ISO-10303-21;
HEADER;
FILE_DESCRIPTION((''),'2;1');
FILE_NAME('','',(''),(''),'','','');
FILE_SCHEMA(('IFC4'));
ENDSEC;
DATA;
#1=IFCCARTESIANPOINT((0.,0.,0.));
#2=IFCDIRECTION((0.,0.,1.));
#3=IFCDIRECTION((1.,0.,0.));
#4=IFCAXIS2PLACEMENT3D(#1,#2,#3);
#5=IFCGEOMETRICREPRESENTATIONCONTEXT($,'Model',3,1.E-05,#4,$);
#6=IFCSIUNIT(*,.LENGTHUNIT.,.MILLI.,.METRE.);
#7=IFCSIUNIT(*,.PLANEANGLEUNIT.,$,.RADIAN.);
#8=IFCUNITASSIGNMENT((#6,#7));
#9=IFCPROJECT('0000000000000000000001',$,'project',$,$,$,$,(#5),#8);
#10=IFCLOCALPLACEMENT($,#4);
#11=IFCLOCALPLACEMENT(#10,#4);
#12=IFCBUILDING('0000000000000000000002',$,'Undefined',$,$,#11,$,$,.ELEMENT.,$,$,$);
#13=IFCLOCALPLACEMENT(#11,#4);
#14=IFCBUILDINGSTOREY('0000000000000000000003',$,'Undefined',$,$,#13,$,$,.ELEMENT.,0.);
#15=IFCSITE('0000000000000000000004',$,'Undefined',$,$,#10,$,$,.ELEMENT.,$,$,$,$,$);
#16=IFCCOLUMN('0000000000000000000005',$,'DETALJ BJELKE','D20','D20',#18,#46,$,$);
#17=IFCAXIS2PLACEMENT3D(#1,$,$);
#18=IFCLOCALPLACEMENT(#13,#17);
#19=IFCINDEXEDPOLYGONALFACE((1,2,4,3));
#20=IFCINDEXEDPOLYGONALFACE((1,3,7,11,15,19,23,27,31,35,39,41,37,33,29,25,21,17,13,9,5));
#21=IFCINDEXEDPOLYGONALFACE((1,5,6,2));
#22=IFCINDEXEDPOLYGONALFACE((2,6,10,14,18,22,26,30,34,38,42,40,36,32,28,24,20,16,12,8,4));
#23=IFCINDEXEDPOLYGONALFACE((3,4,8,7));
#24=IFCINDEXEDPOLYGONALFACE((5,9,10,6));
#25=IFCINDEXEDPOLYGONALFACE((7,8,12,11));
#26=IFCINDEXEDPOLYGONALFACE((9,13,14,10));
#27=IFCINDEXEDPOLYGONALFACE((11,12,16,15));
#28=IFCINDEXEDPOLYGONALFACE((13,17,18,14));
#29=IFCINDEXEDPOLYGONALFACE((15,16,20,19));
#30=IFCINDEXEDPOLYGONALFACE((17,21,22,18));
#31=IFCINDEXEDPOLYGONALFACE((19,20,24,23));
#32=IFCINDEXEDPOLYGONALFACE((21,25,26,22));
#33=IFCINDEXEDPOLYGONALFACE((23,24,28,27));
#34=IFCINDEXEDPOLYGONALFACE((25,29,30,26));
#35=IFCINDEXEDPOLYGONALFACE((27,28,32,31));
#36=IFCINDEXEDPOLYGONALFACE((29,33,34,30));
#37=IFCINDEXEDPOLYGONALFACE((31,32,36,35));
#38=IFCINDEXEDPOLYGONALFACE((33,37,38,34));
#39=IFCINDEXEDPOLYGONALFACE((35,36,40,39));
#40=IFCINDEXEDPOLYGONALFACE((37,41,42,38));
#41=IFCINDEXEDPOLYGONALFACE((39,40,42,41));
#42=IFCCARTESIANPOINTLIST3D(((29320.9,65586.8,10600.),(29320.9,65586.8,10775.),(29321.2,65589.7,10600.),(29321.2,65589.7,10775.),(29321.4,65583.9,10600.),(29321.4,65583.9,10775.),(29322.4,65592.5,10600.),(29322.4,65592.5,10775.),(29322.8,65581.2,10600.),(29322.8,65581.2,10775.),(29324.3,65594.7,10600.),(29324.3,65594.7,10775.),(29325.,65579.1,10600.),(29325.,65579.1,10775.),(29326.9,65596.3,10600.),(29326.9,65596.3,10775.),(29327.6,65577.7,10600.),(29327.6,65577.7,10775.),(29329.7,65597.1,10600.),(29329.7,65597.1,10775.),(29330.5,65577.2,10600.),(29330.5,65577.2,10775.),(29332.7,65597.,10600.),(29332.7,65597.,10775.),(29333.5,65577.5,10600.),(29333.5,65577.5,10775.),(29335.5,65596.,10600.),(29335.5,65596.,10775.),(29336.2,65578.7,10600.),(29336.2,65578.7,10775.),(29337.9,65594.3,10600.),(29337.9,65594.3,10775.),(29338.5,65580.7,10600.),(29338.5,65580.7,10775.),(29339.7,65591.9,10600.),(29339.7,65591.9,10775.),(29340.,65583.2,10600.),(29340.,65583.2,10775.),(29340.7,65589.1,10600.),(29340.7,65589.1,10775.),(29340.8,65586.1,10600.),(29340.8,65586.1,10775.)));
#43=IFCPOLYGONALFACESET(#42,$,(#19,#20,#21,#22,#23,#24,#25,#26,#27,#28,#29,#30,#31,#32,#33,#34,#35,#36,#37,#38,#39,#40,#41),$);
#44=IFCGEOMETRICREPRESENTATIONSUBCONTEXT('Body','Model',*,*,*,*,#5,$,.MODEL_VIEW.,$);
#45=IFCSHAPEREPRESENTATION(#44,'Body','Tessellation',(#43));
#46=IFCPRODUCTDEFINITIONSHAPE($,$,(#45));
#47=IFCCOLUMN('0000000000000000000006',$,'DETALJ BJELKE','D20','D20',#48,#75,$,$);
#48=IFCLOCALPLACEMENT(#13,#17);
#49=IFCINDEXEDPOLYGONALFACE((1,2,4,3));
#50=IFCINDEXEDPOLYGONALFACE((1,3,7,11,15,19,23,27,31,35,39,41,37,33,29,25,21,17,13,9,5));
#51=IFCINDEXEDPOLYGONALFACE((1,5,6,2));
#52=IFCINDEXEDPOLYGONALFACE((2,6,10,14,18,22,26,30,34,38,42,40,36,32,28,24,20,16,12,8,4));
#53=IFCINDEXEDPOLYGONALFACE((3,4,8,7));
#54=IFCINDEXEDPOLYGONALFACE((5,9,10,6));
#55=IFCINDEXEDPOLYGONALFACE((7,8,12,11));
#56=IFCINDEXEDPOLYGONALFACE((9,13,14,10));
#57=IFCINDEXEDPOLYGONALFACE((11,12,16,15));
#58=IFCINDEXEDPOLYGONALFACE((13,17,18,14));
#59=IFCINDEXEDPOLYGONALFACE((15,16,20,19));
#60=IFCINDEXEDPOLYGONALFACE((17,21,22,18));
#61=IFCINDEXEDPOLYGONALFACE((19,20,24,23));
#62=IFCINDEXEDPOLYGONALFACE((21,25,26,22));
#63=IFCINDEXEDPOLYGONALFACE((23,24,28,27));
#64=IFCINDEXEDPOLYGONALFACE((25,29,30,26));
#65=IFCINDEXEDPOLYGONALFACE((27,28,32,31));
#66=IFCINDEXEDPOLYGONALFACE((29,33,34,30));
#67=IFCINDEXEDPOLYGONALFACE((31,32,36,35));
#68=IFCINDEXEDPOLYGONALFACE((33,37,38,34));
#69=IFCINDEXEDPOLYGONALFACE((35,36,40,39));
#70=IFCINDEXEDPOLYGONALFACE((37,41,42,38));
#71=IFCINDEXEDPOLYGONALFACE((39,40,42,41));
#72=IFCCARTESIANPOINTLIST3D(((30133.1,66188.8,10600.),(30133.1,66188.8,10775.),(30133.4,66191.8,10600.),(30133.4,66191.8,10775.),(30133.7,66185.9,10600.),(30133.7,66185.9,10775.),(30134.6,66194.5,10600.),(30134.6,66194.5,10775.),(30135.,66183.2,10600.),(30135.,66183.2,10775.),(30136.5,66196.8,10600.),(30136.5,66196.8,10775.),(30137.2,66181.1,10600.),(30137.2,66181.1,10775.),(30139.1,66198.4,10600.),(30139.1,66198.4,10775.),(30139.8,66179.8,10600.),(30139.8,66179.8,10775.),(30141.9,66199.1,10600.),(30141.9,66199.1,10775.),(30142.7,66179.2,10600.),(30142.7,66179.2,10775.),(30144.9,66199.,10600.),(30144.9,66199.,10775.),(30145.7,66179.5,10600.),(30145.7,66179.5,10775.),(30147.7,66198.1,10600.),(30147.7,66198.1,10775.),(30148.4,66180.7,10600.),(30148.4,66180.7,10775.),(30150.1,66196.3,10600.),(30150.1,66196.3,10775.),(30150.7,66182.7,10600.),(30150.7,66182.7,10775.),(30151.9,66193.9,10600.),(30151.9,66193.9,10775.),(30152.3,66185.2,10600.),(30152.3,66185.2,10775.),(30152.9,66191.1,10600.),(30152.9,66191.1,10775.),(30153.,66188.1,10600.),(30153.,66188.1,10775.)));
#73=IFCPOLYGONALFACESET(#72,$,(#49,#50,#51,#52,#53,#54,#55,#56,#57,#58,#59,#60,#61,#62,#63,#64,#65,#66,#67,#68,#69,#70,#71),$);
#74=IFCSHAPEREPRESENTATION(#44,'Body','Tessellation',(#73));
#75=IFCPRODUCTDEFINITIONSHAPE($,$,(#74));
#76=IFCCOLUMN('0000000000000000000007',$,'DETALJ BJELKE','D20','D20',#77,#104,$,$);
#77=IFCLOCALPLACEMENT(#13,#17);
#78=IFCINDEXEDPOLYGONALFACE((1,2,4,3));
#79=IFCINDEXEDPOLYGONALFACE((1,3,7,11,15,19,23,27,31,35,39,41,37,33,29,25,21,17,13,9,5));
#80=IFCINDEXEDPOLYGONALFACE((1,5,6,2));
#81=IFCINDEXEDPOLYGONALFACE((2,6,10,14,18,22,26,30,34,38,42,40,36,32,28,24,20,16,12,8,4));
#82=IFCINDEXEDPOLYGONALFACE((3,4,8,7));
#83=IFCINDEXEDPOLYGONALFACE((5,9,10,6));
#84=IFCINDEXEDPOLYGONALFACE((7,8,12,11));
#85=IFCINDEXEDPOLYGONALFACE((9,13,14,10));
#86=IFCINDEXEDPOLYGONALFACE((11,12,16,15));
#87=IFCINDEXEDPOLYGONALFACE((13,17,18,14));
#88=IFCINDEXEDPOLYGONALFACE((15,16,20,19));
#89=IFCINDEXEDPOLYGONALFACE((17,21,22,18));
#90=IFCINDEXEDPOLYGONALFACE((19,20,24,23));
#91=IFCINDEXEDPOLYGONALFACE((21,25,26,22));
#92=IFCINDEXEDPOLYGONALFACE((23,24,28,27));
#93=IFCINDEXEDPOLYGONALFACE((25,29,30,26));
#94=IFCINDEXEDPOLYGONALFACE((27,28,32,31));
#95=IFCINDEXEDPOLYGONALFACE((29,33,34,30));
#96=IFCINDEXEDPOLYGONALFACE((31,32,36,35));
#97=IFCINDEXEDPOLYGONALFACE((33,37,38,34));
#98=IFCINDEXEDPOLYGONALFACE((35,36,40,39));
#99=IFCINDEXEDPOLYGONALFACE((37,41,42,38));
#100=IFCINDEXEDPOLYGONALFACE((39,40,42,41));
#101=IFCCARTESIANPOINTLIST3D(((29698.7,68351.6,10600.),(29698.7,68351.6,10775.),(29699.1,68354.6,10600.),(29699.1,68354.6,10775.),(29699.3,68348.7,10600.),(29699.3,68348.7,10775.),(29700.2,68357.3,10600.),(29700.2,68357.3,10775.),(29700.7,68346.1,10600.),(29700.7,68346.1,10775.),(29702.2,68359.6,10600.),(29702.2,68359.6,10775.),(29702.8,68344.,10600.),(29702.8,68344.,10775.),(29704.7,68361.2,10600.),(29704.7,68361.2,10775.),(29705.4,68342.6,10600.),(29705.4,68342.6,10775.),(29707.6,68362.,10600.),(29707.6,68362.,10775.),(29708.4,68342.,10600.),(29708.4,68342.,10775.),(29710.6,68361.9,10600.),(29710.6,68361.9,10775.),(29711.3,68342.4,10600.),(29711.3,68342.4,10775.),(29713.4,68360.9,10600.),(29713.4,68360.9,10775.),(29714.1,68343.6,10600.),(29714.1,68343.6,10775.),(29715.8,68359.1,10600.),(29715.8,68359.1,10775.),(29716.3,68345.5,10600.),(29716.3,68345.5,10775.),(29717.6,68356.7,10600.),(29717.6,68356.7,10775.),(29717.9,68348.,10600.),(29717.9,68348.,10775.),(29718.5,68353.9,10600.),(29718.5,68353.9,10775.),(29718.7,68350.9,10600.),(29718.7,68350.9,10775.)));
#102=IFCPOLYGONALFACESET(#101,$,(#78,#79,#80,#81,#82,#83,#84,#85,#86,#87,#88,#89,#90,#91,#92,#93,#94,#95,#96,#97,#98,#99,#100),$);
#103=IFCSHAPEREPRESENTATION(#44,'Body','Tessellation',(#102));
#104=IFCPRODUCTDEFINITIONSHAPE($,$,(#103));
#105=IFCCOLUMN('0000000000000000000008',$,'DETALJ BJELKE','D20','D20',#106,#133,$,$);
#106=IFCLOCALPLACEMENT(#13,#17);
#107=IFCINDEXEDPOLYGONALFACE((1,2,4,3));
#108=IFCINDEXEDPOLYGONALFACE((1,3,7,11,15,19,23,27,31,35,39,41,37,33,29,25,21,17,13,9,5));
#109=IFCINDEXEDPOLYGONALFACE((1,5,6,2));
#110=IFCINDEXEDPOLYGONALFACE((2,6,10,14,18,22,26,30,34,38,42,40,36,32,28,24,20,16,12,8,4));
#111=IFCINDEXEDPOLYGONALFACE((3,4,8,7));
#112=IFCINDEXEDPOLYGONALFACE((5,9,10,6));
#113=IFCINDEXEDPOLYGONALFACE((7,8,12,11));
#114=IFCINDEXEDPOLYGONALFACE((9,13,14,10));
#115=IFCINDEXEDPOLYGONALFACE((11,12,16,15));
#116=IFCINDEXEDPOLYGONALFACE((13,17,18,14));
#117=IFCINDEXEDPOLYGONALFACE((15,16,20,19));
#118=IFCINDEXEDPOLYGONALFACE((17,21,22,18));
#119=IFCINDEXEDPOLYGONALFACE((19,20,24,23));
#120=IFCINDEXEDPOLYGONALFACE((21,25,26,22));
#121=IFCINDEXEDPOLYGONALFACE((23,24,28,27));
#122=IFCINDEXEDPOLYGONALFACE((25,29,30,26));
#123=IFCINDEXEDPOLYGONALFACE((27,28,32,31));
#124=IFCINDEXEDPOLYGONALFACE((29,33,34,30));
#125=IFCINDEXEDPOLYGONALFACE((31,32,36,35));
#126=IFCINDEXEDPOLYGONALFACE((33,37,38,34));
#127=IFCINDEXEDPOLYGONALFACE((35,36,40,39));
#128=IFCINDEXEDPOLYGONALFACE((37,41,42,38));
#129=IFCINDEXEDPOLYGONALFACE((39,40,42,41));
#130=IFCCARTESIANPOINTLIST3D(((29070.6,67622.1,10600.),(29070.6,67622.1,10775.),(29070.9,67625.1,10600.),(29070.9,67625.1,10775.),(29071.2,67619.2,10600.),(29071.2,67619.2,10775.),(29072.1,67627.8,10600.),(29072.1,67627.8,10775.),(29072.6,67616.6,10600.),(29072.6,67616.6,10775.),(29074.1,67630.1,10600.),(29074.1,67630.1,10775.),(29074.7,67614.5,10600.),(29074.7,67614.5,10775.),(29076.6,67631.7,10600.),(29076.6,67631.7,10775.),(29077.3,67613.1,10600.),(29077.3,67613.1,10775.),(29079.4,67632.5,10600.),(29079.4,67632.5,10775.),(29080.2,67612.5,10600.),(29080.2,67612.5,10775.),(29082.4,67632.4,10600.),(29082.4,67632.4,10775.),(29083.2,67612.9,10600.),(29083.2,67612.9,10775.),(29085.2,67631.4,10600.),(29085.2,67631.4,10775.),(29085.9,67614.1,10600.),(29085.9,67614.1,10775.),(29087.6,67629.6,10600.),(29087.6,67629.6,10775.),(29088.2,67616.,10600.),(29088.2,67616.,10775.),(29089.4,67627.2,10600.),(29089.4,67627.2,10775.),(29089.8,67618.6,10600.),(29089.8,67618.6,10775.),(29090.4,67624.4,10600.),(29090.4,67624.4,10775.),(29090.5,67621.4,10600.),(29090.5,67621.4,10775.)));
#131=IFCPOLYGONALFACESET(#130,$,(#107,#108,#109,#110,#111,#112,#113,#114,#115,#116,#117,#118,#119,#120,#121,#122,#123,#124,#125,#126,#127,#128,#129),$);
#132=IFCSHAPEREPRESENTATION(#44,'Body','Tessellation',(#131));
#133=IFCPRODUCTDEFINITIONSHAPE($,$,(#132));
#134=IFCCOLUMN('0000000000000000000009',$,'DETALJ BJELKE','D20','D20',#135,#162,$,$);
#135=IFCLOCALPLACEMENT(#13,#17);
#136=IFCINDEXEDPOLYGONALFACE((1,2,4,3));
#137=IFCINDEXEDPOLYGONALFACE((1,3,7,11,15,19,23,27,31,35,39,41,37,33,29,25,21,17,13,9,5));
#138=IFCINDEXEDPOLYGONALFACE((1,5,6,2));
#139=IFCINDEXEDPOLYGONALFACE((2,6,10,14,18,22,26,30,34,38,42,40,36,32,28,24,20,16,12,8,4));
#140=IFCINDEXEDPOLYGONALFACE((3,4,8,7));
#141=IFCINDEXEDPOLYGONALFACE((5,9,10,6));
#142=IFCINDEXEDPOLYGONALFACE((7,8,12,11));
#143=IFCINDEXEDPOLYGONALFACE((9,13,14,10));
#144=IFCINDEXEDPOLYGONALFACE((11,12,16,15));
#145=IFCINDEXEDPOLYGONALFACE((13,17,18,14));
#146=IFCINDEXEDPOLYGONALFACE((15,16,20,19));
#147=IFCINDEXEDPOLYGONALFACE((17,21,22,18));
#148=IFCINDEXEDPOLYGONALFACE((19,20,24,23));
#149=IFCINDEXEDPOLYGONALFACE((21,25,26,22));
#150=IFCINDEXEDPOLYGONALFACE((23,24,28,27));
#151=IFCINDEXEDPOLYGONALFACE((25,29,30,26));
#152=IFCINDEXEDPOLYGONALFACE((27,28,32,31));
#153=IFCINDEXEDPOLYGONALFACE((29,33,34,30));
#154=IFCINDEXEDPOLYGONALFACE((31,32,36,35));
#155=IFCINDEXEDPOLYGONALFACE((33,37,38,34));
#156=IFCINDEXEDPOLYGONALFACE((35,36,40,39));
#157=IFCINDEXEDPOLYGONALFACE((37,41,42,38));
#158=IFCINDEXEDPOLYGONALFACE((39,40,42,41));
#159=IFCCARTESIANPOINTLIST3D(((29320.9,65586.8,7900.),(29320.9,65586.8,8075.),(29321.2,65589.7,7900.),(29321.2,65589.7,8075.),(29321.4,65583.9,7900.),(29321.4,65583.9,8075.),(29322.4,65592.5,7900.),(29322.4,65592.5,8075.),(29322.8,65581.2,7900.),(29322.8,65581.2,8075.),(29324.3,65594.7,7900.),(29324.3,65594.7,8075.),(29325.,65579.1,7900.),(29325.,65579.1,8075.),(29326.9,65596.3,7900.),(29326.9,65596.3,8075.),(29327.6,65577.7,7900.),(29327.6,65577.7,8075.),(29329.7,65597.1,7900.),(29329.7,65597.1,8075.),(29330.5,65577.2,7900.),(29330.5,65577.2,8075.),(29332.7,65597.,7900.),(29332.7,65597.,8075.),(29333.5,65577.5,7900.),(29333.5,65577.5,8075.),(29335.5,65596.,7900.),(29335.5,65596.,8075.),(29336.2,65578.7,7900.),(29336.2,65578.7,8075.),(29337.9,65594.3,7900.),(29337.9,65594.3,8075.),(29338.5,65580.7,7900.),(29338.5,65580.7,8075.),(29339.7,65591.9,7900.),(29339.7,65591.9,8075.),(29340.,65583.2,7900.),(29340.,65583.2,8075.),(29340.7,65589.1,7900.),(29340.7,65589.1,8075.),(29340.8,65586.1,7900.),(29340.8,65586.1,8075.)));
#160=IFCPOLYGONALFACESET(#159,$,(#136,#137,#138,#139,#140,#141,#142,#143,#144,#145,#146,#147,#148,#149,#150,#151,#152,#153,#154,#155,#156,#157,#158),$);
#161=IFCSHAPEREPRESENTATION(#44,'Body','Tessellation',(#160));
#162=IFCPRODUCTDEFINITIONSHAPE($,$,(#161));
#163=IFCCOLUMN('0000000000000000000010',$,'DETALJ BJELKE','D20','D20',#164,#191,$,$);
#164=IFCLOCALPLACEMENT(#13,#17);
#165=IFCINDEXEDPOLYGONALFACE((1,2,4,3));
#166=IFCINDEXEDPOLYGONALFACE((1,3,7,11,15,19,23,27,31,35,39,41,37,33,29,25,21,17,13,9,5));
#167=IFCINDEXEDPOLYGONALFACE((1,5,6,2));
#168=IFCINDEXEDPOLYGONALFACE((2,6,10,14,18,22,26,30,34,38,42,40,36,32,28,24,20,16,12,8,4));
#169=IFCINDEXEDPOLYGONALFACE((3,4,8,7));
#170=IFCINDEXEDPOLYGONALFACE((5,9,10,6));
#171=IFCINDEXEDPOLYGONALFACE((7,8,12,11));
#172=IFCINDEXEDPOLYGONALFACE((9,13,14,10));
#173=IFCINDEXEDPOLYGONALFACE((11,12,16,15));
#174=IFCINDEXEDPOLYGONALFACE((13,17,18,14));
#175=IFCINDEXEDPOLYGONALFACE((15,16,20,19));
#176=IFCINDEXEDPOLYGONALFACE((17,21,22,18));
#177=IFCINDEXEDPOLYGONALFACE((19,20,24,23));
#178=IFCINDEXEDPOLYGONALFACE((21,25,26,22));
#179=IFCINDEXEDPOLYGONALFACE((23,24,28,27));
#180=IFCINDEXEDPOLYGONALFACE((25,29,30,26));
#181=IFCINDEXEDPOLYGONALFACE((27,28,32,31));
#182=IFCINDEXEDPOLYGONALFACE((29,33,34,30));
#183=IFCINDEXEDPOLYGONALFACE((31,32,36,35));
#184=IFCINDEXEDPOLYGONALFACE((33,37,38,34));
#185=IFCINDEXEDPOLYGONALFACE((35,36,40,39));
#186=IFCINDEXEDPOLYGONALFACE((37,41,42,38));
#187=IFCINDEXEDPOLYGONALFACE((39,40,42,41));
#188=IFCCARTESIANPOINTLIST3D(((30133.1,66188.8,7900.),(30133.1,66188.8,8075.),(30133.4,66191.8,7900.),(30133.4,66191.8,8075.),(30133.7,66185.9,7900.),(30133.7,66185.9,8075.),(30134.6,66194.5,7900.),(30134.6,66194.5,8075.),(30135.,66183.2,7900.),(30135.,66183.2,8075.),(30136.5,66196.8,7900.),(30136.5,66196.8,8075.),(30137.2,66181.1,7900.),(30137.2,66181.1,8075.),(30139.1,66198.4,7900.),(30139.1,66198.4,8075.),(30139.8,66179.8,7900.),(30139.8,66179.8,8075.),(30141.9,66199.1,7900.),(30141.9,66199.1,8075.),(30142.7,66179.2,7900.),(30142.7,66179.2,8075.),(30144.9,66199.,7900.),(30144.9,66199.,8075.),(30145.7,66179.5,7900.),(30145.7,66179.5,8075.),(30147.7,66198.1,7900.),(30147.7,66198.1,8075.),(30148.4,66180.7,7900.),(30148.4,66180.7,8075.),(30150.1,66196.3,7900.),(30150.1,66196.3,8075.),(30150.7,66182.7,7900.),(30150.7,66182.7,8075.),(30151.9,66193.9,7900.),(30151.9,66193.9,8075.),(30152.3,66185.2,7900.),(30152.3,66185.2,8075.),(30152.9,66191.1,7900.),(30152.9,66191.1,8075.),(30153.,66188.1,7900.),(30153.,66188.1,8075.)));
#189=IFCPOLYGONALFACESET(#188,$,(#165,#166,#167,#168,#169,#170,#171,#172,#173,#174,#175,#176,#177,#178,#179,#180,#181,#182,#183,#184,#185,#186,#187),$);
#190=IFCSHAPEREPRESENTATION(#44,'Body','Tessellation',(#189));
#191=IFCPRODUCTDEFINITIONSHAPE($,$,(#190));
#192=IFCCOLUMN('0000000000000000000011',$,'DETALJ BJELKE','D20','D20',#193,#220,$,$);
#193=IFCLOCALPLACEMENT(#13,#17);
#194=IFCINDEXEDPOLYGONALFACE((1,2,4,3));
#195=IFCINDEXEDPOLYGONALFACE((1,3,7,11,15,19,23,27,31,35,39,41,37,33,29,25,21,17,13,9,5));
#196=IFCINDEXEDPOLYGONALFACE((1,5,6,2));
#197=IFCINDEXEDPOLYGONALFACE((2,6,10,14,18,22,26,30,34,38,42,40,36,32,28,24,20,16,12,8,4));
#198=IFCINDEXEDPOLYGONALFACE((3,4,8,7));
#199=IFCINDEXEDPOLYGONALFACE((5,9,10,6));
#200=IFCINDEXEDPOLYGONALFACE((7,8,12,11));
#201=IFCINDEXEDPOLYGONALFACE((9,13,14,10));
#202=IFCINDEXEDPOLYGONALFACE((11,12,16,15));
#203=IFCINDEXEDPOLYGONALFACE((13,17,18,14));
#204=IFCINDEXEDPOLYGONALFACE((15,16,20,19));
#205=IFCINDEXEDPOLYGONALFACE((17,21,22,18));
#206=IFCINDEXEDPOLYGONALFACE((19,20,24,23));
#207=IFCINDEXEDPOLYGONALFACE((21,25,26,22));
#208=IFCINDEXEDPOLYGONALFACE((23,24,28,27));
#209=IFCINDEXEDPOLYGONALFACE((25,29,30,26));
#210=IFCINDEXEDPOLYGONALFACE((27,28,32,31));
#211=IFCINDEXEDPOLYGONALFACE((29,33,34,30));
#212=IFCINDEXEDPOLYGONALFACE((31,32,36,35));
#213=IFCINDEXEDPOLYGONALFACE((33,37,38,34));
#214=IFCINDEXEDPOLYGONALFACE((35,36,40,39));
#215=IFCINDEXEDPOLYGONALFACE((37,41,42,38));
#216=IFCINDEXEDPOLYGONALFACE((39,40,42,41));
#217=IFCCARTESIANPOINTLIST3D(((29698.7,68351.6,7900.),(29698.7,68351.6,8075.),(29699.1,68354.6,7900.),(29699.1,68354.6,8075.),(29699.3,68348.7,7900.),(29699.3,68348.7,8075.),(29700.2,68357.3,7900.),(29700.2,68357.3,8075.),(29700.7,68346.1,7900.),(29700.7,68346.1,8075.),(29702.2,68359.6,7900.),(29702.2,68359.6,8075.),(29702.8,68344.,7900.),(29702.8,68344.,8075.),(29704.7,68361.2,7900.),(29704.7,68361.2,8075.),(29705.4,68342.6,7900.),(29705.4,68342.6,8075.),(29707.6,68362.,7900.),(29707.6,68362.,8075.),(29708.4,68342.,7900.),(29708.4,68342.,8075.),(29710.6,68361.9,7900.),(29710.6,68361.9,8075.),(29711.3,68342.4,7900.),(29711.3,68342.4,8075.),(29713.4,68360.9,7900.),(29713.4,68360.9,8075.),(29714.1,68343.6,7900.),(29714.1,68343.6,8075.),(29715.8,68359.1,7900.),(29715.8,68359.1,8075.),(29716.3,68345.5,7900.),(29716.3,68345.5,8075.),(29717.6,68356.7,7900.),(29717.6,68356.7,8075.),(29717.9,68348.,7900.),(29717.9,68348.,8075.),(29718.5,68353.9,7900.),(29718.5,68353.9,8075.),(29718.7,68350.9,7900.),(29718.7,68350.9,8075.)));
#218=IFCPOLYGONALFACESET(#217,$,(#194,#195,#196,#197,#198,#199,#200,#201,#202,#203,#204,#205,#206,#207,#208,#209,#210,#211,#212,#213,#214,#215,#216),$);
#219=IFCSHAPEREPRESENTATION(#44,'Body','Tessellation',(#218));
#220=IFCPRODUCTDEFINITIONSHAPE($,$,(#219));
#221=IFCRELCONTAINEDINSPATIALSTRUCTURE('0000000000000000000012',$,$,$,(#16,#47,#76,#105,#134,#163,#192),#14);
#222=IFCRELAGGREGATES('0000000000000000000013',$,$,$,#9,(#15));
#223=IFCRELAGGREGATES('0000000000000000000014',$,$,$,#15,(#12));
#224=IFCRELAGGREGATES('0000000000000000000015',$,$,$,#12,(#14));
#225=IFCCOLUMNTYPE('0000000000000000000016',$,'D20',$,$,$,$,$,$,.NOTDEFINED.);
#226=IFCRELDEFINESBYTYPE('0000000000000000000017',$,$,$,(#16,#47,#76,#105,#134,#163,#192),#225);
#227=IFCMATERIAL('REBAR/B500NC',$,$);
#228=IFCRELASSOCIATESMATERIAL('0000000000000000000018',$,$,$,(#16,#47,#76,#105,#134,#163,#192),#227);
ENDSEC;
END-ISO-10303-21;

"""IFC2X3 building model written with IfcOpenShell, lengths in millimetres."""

from ifc_helpers import new_model, si_unit, frame, origin_with_axes, origin_2d_with_axis, place, context, subcontext, project, spatial, circle, extrude, material, type_object, element, save


model = new_model("IFC2X3")

# Units and contexts
model_context = context("Model", 3, precision=1e-05, world=origin_with_axes())
body_context = subcontext(model_context, "Body", "Model", "MODEL_VIEW")
ifc_project = project(units=[si_unit("LENGTHUNIT", "METRE", prefix="MILLI"), si_unit("PLANEANGLEUNIT", "RADIAN")], contexts=[model_context])

# Site, building, storey
site_placement = place(None, origin_with_axes())
site = spatial("IfcSite", under=ifc_project, at=site_placement, Name="Undefined", CompositionType="ELEMENT")
building_placement = place(site_placement, origin_with_axes())
building = spatial("IfcBuilding", under=site, at=building_placement, Name="Undefined", CompositionType="ELEMENT")
storey_placement = place(building_placement, origin_with_axes())
storey = spatial("IfcBuildingStorey", under=building, at=storey_placement, Name="Undefined", CompositionType="ELEMENT", Elevation=0.0)

# Columns
ifc_material_1 = material(Name="REBAR/B500NC")
column_type_1 = type_object("IfcColumnType", Name="D20", PredefinedType="NOTDEFINED")
for number, where, z_axis, x_axis, name in (
    (1, (29330.9, 65587.2, 10600.0), (0.0, 0.0, 1.0), (-0.595472, 0.803376, 0.0), "DETALJ BJELKE"),
    (2, (30143.1, 66189.2, 10600.0), (0.0, 0.0, 1.0), (-0.595472, 0.803376, 0.0), "DETALJ BJELKE"),
    (3, (29708.7, 68352.0, 10600.0), (0.0, 0.0, 1.0), (-0.595472, 0.803376, 0.0), "DETALJ BJELKE"),
    (4, (29080.6, 67622.5, 10600.0), (0.0, 0.0, 1.0), (-0.595472, 0.803376, 0.0), "DETALJ BJELKE"),
    (5, (29330.9, 65587.2, 7900.0), (0.0, 0.0, 1.0), (-0.595472, 0.803376, 0.0), "DETALJ BJELKE"),
    (6, (30143.1, 66189.2, 7900.0), (0.0, 0.0, 1.0), (-0.595472, 0.803376, 0.0), "DETALJ BJELKE"),
    (7, (29708.7, 68352.0, 7900.0), (0.0, 0.0, 1.0), (-0.595472, 0.803376, 0.0), "DETALJ BJELKE"),
):
    element("IfcColumn", number, at=place(storey_placement, frame(where, z_axis=z_axis, x_axis=x_axis)), inside=storey, type_object=column_type_1, material=ifc_material_1, Name=name, Description="D20", ObjectType="D20", context=body_context, shape_type="SweptSolid", body=[
        extrude(circle(Radius=10.0, at=origin_2d_with_axis()), frame((0.0, 0.0, 175.0), z_axis=(0.0, 0.0, -1.0), x_axis=(0.0, 1.0, 0.0)), (0.0, 0.0, 1.0), 175.0),
    ])

save(model, "model.ifc")
